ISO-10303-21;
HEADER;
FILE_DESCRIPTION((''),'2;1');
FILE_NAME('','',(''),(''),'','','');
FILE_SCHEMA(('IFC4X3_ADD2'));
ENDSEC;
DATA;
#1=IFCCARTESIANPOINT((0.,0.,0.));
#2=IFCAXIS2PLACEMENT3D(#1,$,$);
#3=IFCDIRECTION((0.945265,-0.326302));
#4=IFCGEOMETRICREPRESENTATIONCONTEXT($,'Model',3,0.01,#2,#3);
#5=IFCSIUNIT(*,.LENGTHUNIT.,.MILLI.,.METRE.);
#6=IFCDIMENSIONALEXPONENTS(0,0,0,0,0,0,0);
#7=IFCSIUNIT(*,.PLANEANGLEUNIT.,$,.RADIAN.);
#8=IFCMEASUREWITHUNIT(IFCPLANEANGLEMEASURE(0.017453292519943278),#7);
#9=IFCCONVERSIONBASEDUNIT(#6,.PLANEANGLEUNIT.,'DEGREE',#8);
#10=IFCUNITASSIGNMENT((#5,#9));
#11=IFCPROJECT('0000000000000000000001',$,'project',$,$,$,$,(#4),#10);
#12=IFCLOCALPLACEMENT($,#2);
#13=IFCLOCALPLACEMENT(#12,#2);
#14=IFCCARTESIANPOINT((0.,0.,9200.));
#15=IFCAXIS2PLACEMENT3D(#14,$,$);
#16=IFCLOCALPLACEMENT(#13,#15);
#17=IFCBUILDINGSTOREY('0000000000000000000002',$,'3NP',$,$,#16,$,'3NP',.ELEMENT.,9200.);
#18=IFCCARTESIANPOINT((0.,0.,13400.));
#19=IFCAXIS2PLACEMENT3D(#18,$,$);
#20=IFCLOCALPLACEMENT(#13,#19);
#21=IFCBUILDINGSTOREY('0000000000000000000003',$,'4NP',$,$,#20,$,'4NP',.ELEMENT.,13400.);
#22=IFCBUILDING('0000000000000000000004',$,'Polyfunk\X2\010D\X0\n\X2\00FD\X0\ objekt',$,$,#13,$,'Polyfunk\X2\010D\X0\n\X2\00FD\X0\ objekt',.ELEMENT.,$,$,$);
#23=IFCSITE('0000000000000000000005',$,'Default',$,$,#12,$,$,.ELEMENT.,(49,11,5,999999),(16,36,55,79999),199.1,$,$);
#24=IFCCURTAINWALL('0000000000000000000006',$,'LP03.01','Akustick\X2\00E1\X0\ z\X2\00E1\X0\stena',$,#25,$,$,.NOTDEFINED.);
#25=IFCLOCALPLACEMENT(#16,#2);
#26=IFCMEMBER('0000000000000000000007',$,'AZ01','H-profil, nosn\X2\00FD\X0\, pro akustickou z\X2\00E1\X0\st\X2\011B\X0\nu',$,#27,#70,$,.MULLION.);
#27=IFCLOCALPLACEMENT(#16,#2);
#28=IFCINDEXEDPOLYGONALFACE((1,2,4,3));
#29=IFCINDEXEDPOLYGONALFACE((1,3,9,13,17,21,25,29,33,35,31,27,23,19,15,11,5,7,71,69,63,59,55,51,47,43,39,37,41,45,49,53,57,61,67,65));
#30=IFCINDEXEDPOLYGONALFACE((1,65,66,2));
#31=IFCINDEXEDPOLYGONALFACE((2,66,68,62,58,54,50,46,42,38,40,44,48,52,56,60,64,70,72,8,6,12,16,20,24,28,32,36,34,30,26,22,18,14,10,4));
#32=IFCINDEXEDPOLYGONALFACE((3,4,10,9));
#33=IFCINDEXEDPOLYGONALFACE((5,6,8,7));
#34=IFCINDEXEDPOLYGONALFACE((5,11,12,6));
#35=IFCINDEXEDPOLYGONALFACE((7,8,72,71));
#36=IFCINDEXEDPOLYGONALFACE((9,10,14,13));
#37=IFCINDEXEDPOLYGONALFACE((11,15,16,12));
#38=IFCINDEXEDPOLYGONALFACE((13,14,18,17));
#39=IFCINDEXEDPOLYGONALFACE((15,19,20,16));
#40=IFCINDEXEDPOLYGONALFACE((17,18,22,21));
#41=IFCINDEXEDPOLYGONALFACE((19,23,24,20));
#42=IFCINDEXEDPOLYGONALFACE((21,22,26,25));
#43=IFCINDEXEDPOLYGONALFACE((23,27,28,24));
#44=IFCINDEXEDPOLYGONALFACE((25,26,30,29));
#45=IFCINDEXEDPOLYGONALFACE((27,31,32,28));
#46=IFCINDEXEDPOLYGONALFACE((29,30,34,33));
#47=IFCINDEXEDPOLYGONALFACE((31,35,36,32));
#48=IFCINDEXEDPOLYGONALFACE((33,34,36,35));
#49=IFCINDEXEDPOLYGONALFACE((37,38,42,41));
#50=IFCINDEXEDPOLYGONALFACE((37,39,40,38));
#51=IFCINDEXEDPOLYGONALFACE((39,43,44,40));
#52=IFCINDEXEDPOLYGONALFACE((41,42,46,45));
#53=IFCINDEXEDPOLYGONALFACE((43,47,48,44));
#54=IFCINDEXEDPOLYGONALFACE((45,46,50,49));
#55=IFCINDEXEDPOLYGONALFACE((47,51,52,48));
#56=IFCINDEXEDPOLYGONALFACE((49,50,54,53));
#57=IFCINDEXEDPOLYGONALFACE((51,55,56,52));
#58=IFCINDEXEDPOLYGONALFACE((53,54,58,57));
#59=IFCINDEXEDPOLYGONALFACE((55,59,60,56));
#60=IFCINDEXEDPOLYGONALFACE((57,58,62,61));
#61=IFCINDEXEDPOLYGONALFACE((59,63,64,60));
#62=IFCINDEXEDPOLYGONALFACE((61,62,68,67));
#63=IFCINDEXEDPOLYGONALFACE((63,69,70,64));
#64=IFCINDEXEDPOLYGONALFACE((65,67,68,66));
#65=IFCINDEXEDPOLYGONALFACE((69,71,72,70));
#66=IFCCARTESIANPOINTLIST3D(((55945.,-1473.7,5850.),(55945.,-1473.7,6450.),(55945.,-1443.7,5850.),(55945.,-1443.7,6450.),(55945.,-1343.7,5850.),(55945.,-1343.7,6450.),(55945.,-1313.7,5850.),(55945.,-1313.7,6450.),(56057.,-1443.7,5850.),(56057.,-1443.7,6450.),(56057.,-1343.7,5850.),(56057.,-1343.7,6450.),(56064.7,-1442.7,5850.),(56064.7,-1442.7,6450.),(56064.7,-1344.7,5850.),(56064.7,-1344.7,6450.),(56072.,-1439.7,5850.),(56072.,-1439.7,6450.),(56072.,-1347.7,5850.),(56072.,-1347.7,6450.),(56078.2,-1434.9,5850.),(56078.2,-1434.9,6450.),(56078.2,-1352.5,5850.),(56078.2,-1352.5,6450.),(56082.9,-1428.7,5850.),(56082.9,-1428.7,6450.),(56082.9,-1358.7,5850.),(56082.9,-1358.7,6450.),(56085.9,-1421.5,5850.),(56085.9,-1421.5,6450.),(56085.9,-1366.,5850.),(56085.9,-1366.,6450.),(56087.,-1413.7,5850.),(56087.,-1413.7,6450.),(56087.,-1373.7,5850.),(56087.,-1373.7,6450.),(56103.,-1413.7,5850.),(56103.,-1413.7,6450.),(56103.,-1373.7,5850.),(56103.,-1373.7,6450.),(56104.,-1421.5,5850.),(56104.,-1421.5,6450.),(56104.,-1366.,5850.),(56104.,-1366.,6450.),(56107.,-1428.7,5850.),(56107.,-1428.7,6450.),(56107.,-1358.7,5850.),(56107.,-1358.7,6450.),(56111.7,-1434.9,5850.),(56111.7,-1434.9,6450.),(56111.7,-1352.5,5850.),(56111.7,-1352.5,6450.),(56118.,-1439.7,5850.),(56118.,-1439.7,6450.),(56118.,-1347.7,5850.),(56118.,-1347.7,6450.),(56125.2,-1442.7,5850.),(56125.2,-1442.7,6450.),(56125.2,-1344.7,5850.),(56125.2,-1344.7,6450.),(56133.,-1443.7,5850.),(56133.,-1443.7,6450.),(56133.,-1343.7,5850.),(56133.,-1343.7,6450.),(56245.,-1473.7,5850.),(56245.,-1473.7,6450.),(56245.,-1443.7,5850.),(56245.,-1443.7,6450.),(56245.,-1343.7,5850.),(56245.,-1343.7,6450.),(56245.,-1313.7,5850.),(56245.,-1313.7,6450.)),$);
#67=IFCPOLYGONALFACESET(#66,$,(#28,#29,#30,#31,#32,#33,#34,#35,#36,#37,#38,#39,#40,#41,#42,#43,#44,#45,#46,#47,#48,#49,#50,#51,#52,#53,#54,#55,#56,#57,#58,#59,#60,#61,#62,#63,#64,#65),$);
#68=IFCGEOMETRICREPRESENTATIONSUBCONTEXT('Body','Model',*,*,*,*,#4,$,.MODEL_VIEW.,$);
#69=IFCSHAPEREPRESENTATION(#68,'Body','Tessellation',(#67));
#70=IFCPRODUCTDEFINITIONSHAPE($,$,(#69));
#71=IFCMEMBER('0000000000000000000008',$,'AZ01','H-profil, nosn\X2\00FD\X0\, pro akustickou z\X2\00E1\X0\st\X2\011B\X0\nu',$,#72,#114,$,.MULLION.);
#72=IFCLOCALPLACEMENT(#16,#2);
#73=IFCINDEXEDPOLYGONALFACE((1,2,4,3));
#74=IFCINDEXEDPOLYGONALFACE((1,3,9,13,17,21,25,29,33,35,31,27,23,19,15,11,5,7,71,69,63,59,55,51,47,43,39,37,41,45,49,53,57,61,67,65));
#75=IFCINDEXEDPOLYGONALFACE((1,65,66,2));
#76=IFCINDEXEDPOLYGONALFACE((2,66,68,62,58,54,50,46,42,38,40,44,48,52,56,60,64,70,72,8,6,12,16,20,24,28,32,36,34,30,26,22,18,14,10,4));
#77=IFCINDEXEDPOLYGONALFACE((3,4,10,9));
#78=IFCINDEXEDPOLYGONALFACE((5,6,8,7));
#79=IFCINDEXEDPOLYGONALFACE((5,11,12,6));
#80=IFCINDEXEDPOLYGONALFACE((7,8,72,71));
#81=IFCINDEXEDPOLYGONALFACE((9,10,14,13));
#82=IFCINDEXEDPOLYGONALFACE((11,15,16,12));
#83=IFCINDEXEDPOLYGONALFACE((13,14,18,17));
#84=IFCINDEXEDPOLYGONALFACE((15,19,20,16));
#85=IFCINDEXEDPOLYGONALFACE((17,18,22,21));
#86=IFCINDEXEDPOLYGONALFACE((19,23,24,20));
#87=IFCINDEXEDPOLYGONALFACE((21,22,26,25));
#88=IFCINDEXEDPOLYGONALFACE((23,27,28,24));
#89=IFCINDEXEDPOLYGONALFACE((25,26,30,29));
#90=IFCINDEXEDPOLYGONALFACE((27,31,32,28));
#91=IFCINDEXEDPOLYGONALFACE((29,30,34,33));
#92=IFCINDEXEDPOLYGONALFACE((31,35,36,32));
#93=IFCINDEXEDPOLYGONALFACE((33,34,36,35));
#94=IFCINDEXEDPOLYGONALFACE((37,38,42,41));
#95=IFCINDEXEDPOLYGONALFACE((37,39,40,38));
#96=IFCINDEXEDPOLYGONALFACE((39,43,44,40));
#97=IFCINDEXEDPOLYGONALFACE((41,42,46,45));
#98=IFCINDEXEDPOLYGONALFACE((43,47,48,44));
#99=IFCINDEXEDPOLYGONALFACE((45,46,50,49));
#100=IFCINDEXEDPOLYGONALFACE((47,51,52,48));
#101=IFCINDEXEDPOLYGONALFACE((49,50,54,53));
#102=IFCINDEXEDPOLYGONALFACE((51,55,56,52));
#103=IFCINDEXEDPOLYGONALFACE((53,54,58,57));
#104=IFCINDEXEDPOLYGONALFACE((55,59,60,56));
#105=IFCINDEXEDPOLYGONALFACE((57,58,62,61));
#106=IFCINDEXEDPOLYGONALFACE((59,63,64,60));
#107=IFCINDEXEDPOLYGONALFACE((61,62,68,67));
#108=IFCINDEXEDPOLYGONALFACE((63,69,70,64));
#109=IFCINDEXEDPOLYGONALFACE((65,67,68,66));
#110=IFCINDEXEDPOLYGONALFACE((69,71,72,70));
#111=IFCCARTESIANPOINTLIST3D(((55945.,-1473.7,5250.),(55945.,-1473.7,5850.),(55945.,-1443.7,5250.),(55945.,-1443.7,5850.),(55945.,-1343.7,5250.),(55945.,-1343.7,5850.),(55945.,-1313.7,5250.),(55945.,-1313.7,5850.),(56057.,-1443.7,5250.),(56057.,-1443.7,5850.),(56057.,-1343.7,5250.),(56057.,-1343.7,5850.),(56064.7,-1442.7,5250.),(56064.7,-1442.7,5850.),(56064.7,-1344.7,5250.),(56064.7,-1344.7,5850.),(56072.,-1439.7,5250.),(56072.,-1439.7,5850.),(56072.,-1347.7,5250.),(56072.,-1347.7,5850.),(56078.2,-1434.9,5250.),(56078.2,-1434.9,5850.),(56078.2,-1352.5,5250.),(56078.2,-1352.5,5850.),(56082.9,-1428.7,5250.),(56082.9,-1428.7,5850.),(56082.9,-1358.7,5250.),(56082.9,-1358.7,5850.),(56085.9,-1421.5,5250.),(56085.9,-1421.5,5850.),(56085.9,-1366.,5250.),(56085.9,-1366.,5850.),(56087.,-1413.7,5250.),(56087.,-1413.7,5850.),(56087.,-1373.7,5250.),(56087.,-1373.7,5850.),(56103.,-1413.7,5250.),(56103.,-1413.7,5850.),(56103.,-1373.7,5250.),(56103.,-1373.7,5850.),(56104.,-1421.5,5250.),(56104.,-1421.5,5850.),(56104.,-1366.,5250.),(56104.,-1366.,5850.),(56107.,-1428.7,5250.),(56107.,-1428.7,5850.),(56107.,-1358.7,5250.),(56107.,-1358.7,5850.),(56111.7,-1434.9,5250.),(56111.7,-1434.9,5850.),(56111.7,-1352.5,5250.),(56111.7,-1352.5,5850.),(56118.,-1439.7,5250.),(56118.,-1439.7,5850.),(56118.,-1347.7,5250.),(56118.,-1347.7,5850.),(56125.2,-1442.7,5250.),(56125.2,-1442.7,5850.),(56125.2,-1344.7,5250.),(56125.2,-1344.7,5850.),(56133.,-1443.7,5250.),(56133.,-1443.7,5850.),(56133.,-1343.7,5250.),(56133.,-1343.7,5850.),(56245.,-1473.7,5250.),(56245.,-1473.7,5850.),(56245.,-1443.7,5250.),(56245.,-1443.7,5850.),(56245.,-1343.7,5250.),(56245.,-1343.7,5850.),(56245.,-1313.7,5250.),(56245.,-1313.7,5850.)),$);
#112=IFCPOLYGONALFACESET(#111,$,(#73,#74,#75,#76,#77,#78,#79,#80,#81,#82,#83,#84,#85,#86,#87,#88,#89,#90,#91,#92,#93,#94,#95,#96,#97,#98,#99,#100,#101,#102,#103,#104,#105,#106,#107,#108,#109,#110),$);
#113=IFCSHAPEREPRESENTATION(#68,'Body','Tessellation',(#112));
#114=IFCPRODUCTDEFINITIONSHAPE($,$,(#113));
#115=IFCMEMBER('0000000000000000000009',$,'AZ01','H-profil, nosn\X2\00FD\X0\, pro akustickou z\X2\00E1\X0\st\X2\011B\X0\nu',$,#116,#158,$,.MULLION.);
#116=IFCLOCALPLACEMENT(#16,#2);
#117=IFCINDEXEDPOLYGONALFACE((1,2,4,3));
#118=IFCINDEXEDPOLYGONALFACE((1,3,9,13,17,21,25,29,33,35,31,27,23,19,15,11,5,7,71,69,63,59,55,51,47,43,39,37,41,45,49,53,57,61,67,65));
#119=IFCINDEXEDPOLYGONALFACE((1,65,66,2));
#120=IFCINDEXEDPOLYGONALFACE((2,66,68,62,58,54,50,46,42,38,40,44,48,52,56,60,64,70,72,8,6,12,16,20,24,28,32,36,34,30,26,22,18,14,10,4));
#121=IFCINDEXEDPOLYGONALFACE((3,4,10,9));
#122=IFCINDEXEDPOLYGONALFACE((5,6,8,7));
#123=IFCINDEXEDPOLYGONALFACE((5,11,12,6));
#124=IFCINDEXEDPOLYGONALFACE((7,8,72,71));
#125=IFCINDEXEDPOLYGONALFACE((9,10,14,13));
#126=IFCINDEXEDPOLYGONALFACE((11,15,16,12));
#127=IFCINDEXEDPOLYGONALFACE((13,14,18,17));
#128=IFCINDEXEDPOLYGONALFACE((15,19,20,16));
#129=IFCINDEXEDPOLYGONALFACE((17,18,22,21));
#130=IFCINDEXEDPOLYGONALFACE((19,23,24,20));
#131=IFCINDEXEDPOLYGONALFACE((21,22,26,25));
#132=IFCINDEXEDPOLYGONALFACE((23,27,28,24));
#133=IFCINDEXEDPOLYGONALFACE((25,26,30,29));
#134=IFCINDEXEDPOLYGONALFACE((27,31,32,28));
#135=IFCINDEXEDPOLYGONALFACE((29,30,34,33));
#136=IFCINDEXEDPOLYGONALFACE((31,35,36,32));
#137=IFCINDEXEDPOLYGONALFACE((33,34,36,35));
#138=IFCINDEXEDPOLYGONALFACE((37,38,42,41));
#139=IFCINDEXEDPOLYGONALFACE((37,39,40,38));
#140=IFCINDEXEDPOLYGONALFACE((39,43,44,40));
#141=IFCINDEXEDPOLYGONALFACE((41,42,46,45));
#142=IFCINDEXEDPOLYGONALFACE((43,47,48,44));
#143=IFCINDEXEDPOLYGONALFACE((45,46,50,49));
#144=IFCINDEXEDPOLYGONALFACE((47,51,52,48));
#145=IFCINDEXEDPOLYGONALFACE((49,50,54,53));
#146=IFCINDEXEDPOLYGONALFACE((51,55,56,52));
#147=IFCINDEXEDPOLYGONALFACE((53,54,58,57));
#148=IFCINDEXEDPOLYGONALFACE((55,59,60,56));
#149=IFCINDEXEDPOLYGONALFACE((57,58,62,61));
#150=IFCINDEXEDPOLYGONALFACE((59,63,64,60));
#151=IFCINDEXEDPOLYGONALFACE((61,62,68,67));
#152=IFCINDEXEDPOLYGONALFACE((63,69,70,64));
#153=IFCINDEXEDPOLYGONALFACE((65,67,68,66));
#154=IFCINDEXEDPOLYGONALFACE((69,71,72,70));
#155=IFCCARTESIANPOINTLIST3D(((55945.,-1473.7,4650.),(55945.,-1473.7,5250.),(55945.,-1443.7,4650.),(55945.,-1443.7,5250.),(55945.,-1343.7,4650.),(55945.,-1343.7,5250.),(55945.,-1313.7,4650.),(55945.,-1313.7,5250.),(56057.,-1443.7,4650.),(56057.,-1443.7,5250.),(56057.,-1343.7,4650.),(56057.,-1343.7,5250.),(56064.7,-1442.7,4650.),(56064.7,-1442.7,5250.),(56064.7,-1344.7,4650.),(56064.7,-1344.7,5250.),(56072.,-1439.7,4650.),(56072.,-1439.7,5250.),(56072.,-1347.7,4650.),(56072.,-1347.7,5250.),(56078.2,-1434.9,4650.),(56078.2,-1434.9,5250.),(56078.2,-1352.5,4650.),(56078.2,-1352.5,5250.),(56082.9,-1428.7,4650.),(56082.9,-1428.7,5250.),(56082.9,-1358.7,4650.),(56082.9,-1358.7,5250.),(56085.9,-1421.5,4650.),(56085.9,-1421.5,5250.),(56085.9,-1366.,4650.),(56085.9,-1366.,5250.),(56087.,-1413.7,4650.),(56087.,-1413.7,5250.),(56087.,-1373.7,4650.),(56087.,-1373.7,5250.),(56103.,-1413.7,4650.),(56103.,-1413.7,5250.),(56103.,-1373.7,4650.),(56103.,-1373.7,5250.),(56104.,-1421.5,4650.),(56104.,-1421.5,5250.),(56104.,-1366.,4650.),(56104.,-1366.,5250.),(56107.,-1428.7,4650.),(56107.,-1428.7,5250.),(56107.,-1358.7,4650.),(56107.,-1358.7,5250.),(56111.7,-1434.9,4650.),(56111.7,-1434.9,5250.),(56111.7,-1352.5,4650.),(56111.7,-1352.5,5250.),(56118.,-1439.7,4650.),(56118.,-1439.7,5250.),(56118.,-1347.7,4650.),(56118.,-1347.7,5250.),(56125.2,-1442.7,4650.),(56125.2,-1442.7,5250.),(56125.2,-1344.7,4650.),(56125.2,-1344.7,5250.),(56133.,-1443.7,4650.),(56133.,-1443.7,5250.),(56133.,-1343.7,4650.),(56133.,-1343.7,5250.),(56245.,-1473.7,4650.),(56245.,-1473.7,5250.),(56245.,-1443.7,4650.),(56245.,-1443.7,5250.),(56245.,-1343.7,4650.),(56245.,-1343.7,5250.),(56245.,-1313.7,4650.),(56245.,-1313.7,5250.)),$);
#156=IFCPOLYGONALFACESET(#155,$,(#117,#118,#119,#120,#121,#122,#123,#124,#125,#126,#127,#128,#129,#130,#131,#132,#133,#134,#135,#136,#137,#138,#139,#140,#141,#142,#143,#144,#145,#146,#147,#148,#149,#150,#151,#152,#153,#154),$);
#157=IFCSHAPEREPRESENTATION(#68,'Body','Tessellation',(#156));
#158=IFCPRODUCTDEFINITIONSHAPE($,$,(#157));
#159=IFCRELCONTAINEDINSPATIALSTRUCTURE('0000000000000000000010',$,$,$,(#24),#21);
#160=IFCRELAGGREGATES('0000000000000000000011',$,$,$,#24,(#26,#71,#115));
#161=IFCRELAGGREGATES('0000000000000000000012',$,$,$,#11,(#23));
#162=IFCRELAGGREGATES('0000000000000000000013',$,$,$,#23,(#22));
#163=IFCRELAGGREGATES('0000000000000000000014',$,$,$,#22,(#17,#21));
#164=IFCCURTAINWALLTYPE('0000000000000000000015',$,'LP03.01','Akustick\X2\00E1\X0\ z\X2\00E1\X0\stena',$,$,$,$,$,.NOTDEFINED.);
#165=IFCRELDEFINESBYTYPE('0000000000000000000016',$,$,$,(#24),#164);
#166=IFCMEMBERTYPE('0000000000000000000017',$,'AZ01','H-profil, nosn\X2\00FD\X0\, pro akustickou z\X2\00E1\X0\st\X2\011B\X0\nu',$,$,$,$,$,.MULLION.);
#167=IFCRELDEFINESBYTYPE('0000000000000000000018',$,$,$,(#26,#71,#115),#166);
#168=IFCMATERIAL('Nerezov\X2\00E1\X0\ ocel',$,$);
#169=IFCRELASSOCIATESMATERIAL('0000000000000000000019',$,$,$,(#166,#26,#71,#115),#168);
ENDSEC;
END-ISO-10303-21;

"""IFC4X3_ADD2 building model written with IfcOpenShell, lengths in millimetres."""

from ifc_helpers import new_model, entity, si_unit, converted_unit, direction, frame, frame_2d, origin, place, context, subcontext, project, spatial, polyline, circle_curve, parameter, trimmed, segment, composite_curve, outline, extrude, source, transform, mapped, material, material_profile, profile_set, profile_usage, type_object, element, aggregate, save


model = new_model("IFC4X3_ADD2")

# Units and contexts
model_context = context("Model", 3, precision=0.01, world=origin(), true_north=direction((0.945265, -0.326302)))
body_context = subcontext(model_context, "Body", "Model", "MODEL_VIEW")
ifc_project = project(units=[si_unit("LENGTHUNIT", "METRE", prefix="MILLI"), converted_unit("PLANEANGLEUNIT", "DEGREE", entity("IfcPlaneAngleMeasure", 0.017453292519943278), si_unit("PLANEANGLEUNIT", "RADIAN"), dimensions=[0, 0, 0, 0, 0, 0, 0])], contexts=[model_context])

# Site, building, storey
site_placement = place(None, origin())
site = spatial("IfcSite", under=ifc_project, at=site_placement, Name="Default", CompositionType="ELEMENT", RefLatitude=(49, 11, 5, 999999), RefLongitude=(16, 36, 55, 79999), RefElevation=199.1)
building_placement = place(site_placement, origin())
building = spatial("IfcBuilding", under=site, at=building_placement, Name="Polyfunkčný objekt", LongName="Polyfunkčný objekt", CompositionType="ELEMENT")
storey_1_placement = place(building_placement, frame((0.0, 0.0, 9200.0)))
storey_1 = spatial("IfcBuildingStorey", under=building, at=storey_1_placement, Name="3NP", LongName="3NP", CompositionType="ELEMENT", Elevation=9200.0)

# Shared definitions
storey_2_placement = place(building_placement, frame((0.0, 0.0, 13400.0)))
storey_2 = spatial("IfcBuildingStorey", under=building, at=storey_2_placement, Name="4NP", LongName="4NP", CompositionType="ELEMENT", Elevation=13400.0)

# Curtain wall, members
curtain_wall_type_1 = type_object("IfcCurtainWallType", Name="LP03.01", Description="Akustická zástena", PredefinedType="NOTDEFINED")
curtain_wall_1_placement = place(storey_2_placement, frame((0.0, 0.0, -13400.0)))
curtain_wall_1 = element("IfcCurtainWall", 1, at=curtain_wall_1_placement, inside=storey_2, type_object=curtain_wall_type_1, Name="LP03.01", Description="Akustická zástena", PredefinedType="NOTDEFINED")
ifc_material_1 = material(Name="Nerezová ocel")
ifc_material_profile_1 = material_profile(ifc_material_1, outline(composite_curve([segment(polyline([(50.0, -150.0), (80.0, -150.0)]), True, "CONTINUOUS"), segment(polyline([(80.0, -150.0), (80.0, 150.0)]), True, "CONTINUOUS"), segment(polyline([(80.0, 150.0), (50.0, 150.0)]), True, "CONTINUOUS"), segment(polyline([(50.0, 150.0), (50.0, 38.0)]), True, "CONTINUOUS"), segment(trimmed(circle_curve(frame_2d((20.0, 38.0), x_axis=(0.0, 1.0)), 30.0), [parameter(180.0)], [parameter(270.0)], True, "PARAMETER"), False, "CONTINUOUS"), segment(polyline([(20.0, 8.0), (-20.0, 8.0)]), True, "CONTINUOUS"), segment(trimmed(circle_curve(frame_2d((-20.0, 38.0), x_axis=(0.0, 1.0)), 30.0), [parameter(90.0)], [parameter(180.0)], True, "PARAMETER"), False, "CONTINUOUS"), segment(polyline([(-50.0, 38.0), (-50.0, 150.0)]), True, "CONTINUOUS"), segment(polyline([(-50.0, 150.0), (-80.0, 150.0)]), True, "CONTINUOUS"), segment(polyline([(-80.0, 150.0), (-80.0, -150.0)]), True, "CONTINUOUS"), segment(polyline([(-80.0, -150.0), (-50.0, -150.0)]), True, "CONTINUOUS"), segment(polyline([(-50.0, -150.0), (-50.0, -38.0)]), True, "CONTINUOUS"), segment(trimmed(circle_curve(frame_2d((-20.0, -38.0), x_axis=(0.0, 1.0)), 30.0), [parameter(0.0)], [parameter(90.0)], True, "PARAMETER"), False, "CONTINUOUS"), segment(polyline([(-20.0, -8.0), (20.0, -8.0)]), True, "CONTINUOUS"), segment(trimmed(circle_curve(frame_2d((20.0, -38.0), x_axis=(0.0, 1.0)), 30.0), [parameter(270.0)], [parameter(0.0)], True, "PARAMETER"), False, "CONTINUOUS"), segment(polyline([(50.0, -38.0), (50.0, -150.0)]), True, "CONTINUOUS")], self_intersect=False)), Name="Profil zástena")
ifc_profile_set_1 = profile_set([ifc_material_profile_1], Name="Profil zástena")
ifc_profile_usage_1 = profile_usage(ifc_profile_set_1)
member_type_1 = type_object("IfcMemberType", Name="AZ01", Description="H-profil, nosný, pro akustickou zástěnu", PredefinedType="MULLION", material=ifc_profile_set_1)
shared_shape_1 = source(origin(), body_context, "Body", "SweptSolid", [
    extrude(outline(composite_curve([segment(polyline([(50.0, -150.0), (80.0, -150.0)]), True, "CONTINUOUS"), segment(polyline([(80.0, -150.0), (80.0, 150.0)]), True, "CONTINUOUS"), segment(polyline([(80.0, 150.0), (50.0, 150.0)]), True, "CONTINUOUS"), segment(polyline([(50.0, 150.0), (50.0, 38.0)]), True, "CONTINUOUS"), segment(trimmed(circle_curve(frame_2d((20.0, 38.0), x_axis=(0.0, 1.0)), 30.0), [parameter(180.0)], [parameter(270.0)], True, "PARAMETER"), False, "CONTINUOUS"), segment(polyline([(20.0, 8.0), (-20.0, 8.0)]), True, "CONTINUOUS"), segment(trimmed(circle_curve(frame_2d((-20.0, 38.0), x_axis=(0.0, 1.0)), 30.0), [parameter(90.0)], [parameter(180.0)], True, "PARAMETER"), False, "CONTINUOUS"), segment(polyline([(-50.0, 38.0), (-50.0, 150.0)]), True, "CONTINUOUS"), segment(polyline([(-50.0, 150.0), (-80.0, 150.0)]), True, "CONTINUOUS"), segment(polyline([(-80.0, 150.0), (-80.0, -150.0)]), True, "CONTINUOUS"), segment(polyline([(-80.0, -150.0), (-50.0, -150.0)]), True, "CONTINUOUS"), segment(polyline([(-50.0, -150.0), (-50.0, -38.0)]), True, "CONTINUOUS"), segment(trimmed(circle_curve(frame_2d((-20.0, -38.0), x_axis=(0.0, 1.0)), 30.0), [parameter(0.0)], [parameter(90.0)], True, "PARAMETER"), False, "CONTINUOUS"), segment(polyline([(-20.0, -8.0), (20.0, -8.0)]), True, "CONTINUOUS"), segment(trimmed(circle_curve(frame_2d((20.0, -38.0), x_axis=(0.0, 1.0)), 30.0), [parameter(270.0)], [parameter(0.0)], True, "PARAMETER"), False, "CONTINUOUS"), segment(polyline([(50.0, -38.0), (50.0, -150.0)]), True, "CONTINUOUS")], self_intersect=False)), frame((-150.0, 0.0, -600.0), z_axis=(0.0, 0.0, 1.0), x_axis=(0.0, -1.0, 0.0)), (0.0, 0.0, 1.0), 600.0),
])
member_1_placement = place(curtain_wall_1_placement, frame((56245.0, -1393.7, 15050.0), z_axis=(0.0, 0.0, -1.0), x_axis=(1.0, 0.0, 0.0)))
member_1 = element("IfcMember", 2, at=member_1_placement, type_object=member_type_1, material=ifc_profile_usage_1, Name="AZ01", Description="H-profil, nosný, pro akustickou zástěnu", PredefinedType="MULLION", context=body_context, shape_type="MappedRepresentation", body=[
    mapped(shared_shape_1, transform((0.0, 0.0, 0.0), scale=1.0)),
])
member_2_placement = place(curtain_wall_1_placement, frame((56245.0, -1393.7, 14450.0), z_axis=(0.0, 0.0, -1.0), x_axis=(1.0, 0.0, 0.0)))
member_2 = element("IfcMember", 3, at=member_2_placement, type_object=member_type_1, material=ifc_profile_usage_1, Name="AZ01", Description="H-profil, nosný, pro akustickou zástěnu", PredefinedType="MULLION", context=body_context, shape_type="MappedRepresentation", body=[
    mapped(shared_shape_1, transform((0.0, 0.0, 0.0), scale=1.0)),
])
member_3_placement = place(curtain_wall_1_placement, frame((56245.0, -1393.7, 13850.0), z_axis=(0.0, 0.0, -1.0), x_axis=(1.0, 0.0, 0.0)))
member_3 = element("IfcMember", 4, at=member_3_placement, type_object=member_type_1, material=ifc_profile_usage_1, Name="AZ01", Description="H-profil, nosný, pro akustickou zástěnu", PredefinedType="MULLION", context=body_context, shape_type="MappedRepresentation", body=[
    mapped(shared_shape_1, transform((0.0, 0.0, 0.0), scale=1.0)),
])
aggregate(curtain_wall_1, [member_1, member_2, member_3])

save(model, "model.ifc")
